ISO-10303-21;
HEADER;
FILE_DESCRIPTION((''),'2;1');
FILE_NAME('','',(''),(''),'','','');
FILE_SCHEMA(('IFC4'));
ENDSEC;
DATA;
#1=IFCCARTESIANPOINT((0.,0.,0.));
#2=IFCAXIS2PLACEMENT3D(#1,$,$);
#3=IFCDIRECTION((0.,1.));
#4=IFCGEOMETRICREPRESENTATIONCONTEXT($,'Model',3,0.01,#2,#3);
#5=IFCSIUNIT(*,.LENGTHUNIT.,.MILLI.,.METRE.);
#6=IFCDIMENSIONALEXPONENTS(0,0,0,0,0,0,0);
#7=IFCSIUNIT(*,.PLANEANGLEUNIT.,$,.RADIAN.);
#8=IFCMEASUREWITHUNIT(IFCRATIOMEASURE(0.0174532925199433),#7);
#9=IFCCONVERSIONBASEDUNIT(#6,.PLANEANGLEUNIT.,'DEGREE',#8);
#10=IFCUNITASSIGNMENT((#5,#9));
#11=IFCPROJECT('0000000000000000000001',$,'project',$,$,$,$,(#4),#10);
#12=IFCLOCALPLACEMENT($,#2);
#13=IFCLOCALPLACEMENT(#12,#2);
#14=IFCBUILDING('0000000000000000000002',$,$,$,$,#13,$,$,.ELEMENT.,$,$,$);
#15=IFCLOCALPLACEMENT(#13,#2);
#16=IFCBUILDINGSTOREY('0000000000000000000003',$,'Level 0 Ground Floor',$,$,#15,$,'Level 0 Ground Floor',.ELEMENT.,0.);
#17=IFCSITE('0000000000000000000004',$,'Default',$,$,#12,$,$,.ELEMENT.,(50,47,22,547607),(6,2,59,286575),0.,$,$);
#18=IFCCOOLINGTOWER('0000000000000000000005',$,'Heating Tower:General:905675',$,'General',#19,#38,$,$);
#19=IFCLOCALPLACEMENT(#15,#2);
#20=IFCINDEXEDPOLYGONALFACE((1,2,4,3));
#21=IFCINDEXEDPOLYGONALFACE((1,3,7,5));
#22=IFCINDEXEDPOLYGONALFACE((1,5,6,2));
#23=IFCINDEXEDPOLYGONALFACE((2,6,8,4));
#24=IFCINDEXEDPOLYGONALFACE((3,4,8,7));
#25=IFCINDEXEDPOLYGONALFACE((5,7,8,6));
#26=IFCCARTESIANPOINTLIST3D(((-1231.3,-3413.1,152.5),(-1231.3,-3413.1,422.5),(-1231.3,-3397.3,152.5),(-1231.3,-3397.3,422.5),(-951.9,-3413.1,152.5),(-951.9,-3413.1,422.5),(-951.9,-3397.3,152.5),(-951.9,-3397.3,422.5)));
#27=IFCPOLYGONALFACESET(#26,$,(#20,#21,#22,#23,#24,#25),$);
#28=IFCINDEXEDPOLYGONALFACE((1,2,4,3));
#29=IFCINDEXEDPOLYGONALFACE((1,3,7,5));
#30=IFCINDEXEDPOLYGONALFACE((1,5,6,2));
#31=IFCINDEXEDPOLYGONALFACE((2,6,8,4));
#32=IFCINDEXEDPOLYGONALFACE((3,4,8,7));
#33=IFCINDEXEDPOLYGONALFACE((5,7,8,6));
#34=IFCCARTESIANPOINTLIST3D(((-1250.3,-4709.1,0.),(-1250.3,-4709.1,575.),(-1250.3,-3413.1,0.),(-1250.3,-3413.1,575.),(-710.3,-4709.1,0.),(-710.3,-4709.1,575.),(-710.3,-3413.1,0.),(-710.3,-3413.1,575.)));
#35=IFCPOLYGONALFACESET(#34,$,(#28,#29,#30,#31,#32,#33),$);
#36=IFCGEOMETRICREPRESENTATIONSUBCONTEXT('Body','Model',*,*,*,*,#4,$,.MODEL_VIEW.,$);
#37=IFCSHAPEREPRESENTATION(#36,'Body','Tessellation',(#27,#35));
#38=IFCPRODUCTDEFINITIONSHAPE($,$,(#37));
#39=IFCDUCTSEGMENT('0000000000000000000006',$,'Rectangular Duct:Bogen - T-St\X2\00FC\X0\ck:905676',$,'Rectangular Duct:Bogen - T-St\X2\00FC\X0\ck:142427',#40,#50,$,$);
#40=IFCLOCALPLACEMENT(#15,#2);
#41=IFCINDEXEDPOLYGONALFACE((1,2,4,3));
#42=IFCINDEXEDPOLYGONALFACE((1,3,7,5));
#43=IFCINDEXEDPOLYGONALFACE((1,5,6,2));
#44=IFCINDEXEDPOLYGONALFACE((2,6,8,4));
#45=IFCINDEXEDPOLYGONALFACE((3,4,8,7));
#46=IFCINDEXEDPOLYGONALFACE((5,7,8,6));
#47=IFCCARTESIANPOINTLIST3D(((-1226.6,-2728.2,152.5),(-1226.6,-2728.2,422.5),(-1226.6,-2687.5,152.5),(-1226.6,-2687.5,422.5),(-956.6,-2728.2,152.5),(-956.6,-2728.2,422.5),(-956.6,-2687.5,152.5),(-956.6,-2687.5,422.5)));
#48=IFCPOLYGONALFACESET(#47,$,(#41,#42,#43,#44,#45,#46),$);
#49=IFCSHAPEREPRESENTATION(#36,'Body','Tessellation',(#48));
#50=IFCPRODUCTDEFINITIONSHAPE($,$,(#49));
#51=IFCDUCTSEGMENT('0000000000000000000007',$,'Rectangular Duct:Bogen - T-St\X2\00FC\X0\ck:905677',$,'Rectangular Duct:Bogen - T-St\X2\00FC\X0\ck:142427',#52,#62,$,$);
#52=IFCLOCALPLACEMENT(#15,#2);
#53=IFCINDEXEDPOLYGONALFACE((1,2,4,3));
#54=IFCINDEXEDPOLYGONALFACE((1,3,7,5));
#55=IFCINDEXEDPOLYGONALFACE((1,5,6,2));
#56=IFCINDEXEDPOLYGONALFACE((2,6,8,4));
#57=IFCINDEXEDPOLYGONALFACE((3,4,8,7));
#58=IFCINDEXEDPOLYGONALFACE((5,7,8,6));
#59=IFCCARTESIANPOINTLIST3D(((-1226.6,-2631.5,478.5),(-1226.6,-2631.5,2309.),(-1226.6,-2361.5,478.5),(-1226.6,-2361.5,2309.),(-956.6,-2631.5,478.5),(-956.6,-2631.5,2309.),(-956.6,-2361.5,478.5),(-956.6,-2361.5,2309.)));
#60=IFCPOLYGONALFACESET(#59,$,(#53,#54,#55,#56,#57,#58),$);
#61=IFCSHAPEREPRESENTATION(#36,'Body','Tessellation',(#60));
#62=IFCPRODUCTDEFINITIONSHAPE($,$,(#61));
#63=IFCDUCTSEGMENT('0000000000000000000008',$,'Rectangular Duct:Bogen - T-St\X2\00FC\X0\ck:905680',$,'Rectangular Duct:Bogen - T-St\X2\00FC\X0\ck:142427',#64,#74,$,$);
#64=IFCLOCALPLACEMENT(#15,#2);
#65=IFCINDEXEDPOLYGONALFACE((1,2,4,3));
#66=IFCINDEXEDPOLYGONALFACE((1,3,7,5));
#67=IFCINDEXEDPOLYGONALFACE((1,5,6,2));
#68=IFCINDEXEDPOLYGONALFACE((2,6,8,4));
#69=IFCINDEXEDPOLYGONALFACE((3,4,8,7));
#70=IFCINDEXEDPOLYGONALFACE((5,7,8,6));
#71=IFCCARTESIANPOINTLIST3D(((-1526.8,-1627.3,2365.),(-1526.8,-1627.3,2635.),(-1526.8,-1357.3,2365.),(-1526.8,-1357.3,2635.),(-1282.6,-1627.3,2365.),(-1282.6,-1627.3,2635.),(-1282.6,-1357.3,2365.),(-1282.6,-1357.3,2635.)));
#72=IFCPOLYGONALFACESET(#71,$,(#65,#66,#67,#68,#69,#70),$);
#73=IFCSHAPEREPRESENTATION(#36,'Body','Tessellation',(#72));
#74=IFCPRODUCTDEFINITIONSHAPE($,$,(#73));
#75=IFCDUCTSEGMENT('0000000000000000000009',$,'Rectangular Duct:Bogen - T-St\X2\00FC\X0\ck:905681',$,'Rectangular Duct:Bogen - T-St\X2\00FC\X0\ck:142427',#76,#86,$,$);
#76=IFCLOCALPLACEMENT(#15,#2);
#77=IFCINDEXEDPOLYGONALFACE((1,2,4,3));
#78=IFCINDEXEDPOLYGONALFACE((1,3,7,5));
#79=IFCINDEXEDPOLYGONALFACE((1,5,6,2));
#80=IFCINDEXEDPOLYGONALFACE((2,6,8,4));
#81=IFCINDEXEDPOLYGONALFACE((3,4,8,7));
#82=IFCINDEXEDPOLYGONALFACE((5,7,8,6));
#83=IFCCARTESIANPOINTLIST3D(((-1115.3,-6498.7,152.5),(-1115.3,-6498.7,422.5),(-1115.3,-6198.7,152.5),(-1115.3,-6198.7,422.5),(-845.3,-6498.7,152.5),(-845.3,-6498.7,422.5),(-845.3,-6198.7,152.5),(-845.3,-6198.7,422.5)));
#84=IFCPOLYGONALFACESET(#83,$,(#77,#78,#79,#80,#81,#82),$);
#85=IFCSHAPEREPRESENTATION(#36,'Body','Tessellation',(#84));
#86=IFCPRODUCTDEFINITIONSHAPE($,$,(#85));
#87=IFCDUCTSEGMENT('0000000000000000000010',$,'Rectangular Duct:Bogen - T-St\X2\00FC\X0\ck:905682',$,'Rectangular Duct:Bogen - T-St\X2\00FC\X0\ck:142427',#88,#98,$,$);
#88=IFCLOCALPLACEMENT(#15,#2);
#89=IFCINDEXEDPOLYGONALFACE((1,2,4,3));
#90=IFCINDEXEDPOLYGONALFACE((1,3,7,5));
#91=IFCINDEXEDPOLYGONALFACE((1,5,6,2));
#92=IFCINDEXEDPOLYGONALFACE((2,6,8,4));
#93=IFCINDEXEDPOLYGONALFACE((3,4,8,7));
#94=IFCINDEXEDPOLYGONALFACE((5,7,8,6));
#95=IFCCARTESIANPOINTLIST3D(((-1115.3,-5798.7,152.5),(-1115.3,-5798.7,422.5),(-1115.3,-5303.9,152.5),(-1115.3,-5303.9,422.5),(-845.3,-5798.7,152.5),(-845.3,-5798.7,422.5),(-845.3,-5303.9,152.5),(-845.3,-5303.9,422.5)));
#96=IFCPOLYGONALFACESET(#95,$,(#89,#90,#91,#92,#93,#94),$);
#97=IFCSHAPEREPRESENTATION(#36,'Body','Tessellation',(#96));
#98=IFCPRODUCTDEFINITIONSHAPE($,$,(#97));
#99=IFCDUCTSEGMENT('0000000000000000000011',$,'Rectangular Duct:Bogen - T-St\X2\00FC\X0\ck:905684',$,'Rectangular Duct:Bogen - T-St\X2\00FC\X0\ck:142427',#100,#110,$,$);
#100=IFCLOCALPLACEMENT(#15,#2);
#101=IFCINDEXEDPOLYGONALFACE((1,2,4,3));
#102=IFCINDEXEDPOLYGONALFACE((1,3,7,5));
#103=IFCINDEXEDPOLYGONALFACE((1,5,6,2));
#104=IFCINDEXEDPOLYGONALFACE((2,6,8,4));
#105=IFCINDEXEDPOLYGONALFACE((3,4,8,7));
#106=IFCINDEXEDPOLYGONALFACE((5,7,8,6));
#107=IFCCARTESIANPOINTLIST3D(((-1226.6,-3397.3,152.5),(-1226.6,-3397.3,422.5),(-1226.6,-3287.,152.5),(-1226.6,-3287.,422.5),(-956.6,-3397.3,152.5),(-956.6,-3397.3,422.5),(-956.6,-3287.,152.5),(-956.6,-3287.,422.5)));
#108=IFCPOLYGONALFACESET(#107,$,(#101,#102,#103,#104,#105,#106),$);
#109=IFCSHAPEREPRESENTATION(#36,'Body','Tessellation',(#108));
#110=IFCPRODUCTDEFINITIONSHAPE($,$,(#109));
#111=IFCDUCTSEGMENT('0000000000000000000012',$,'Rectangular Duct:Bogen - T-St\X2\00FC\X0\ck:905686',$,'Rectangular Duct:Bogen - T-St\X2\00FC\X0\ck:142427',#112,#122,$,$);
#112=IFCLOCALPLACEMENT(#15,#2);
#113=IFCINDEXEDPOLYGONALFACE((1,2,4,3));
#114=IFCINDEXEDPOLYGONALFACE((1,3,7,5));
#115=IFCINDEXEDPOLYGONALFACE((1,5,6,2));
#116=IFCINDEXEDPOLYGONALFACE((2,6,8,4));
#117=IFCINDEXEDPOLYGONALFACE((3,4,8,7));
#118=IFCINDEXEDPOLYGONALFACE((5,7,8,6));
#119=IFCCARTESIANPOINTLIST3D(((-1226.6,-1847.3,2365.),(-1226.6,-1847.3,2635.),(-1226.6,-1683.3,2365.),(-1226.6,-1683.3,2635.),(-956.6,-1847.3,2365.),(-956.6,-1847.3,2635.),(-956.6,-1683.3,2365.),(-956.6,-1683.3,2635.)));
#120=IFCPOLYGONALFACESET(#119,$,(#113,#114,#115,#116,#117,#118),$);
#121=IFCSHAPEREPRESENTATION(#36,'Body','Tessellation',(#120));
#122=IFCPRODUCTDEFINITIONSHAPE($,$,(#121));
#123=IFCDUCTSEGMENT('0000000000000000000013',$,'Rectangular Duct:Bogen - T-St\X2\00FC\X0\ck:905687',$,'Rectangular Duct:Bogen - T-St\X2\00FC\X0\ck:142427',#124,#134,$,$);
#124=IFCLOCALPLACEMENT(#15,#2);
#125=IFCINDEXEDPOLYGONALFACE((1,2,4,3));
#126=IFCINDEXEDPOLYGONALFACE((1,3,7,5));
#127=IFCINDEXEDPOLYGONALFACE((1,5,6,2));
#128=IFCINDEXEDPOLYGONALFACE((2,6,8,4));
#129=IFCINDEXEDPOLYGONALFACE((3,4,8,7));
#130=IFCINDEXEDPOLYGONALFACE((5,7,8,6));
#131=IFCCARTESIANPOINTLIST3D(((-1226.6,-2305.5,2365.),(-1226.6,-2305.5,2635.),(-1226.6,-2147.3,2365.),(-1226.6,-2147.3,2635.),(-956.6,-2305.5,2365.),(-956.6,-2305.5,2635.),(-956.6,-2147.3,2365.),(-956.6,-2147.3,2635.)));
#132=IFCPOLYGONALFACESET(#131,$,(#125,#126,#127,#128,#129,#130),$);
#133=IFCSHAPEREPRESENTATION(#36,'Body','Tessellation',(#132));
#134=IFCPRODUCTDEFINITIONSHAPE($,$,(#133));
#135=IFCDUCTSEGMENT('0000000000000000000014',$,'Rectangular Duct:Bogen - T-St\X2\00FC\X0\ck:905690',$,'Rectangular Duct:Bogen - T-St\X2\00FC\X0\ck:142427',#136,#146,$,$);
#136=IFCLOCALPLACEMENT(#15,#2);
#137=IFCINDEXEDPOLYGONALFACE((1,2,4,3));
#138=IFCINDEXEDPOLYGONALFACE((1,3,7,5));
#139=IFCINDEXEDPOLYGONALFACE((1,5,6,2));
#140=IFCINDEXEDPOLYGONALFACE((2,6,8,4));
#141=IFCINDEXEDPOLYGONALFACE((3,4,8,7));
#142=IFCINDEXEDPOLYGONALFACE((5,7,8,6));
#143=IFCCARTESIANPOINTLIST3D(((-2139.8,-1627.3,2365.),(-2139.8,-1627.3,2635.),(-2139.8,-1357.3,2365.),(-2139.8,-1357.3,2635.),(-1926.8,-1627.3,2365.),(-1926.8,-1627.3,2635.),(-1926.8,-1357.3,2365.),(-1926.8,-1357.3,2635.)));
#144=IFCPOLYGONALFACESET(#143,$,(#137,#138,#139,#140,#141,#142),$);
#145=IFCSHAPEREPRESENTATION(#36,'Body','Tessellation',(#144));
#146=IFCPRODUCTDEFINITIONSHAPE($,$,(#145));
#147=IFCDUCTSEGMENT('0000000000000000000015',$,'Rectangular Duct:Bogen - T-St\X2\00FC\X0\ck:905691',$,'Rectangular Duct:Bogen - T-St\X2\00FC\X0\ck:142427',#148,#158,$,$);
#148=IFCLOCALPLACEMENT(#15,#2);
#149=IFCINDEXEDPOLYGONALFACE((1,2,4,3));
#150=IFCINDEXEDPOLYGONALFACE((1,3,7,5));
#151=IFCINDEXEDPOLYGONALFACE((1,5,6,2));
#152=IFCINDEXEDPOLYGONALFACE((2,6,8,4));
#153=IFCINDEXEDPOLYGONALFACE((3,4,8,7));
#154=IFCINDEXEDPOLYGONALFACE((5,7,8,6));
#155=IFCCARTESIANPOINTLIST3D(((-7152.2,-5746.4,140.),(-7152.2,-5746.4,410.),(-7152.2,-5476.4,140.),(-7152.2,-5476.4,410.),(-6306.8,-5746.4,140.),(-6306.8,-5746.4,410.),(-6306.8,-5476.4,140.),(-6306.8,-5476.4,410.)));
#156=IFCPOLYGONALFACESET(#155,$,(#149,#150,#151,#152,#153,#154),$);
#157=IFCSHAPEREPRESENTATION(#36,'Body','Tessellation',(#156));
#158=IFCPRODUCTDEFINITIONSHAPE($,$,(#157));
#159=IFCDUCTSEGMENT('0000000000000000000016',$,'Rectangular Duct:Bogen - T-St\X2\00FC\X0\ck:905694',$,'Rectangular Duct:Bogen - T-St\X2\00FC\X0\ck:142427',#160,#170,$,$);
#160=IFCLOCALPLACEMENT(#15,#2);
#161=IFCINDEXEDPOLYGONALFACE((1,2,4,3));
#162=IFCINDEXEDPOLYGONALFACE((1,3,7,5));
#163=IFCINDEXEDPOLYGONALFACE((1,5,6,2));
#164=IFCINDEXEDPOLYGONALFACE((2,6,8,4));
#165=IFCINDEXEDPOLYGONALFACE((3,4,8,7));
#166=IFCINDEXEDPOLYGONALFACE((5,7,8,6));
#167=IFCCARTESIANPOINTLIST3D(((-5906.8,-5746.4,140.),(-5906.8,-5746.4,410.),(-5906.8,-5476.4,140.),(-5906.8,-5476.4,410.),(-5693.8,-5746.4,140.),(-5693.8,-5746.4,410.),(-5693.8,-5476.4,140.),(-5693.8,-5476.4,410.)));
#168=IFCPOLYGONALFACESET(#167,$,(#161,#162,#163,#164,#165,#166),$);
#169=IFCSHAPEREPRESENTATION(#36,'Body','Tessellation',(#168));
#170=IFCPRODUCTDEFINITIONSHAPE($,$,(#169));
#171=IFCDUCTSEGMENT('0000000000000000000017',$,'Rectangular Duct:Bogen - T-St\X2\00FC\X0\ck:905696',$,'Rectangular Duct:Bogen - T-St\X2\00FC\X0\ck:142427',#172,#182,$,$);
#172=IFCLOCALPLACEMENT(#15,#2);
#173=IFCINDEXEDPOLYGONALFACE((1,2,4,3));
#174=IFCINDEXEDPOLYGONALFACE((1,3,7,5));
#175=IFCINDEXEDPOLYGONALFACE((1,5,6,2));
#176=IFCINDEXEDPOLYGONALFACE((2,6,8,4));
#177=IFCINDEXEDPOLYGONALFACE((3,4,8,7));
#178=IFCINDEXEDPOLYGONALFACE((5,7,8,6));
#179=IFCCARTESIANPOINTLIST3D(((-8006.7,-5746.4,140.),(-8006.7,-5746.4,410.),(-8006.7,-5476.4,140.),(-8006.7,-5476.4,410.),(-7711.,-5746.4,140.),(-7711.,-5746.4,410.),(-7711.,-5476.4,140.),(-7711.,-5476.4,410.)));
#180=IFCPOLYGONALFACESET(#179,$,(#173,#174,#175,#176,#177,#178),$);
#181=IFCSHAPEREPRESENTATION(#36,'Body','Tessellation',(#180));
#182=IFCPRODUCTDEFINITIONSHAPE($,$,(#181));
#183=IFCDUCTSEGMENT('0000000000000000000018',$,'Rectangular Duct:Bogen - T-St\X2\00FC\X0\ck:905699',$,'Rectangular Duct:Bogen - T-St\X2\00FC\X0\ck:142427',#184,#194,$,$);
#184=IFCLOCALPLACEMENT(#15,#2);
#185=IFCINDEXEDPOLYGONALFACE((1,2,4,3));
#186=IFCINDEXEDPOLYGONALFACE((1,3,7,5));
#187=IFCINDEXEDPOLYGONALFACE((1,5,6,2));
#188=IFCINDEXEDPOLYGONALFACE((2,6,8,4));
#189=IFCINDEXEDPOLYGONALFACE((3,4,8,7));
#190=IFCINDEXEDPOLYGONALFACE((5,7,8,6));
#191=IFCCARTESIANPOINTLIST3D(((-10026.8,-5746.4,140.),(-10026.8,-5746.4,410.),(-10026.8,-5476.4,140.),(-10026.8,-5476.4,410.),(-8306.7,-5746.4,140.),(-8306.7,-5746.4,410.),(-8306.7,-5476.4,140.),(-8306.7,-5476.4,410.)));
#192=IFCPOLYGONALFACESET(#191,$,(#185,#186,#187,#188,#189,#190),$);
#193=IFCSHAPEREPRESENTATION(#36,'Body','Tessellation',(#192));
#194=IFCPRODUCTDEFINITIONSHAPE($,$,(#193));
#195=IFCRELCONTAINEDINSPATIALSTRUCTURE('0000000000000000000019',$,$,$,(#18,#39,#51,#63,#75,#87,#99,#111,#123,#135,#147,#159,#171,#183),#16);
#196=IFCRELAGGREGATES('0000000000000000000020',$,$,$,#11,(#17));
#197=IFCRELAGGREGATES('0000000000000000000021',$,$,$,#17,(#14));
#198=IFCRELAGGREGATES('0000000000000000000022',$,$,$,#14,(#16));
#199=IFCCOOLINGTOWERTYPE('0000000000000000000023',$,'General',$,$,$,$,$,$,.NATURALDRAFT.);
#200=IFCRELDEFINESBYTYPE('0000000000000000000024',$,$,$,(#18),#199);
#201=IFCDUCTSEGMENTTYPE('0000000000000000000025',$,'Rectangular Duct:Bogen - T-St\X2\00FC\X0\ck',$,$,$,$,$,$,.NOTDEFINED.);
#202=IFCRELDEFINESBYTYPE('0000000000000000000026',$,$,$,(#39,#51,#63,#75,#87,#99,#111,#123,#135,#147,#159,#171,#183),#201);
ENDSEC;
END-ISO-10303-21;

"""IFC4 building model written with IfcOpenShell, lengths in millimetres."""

from ifc_helpers import new_model, entity, si_unit, converted_unit, direction, frame, frame_2d, origin, origin_2d_with_axis, place, context, subcontext, project, spatial, rectangle, extrude, source, transform, mapped, type_object, type_shapes, element, save


model = new_model("IFC4")

# Units and contexts
model_context = context("Model", 3, precision=0.01, world=origin(), true_north=direction((0.0, 1.0)))
body_context = subcontext(model_context, "Body", "Model", "MODEL_VIEW")
ifc_project = project(units=[si_unit("LENGTHUNIT", "METRE", prefix="MILLI"), converted_unit("PLANEANGLEUNIT", "DEGREE", entity("IfcRatioMeasure", 0.0174532925199433), si_unit("PLANEANGLEUNIT", "RADIAN"), dimensions=[0, 0, 0, 0, 0, 0, 0])], contexts=[model_context])

# Site, building, storey
site_placement = place(None, origin())
site = spatial("IfcSite", under=ifc_project, at=site_placement, Name="Default", CompositionType="ELEMENT", RefLatitude=(50, 47, 22, 547607), RefLongitude=(6, 2, 59, 286575), RefElevation=0.0)
building_placement = place(site_placement, origin())
building = spatial("IfcBuilding", under=site, at=building_placement, CompositionType="ELEMENT")
storey_placement = place(building_placement, origin())
storey = spatial("IfcBuildingStorey", under=building, at=storey_placement, Name="Level 0 Ground Floor", LongName="Level 0 Ground Floor", CompositionType="ELEMENT", Elevation=0.0)

# Cooling tower
cooling_tower_type = type_object("IfcCoolingTowerType", Name="General", PredefinedType="NATURALDRAFT")
shared_shape_1 = source(origin(), body_context, "Body", "SweptSolid", [
    extrude(rectangle(XDim=15.9, YDim=279.4, at=frame_2d((0.0, 0.0), x_axis=(1.0, 0.0))), frame((1303.9, 381.3, 152.5)), (0.0, 0.0, 1.0), 270.0),
    extrude(rectangle(XDim=1296.0, YDim=540.0, at=origin_2d_with_axis()), frame((648.0, 270.0, 0.0), z_axis=(0.0, 0.0, 1.0), x_axis=(-1.0, 0.0, 0.0)), (0.0, 0.0, 1.0), 575.0),
])
type_shapes(cooling_tower_type, [shared_shape_1])
cooling_tower_placement = place(storey_placement, frame((-710.3, -4709.1, 0.0), z_axis=(0.0, 0.0, 1.0), x_axis=(0.0, 1.0, 0.0)))
element("IfcCoolingTower", 1, at=cooling_tower_placement, inside=storey, type_object=cooling_tower_type, Name="Heating Tower:General:905675", ObjectType="General", context=body_context, shape_type="MappedRepresentation", body=[
    mapped(shared_shape_1, transform((0.0, 0.0, 0.0), scale=1.0)),
])

# Duct segments
duct_segment_type = type_object("IfcDuctSegmentType", Name="Rectangular Duct:Bogen - T-Stück", PredefinedType="NOTDEFINED")
duct_segment_1_placement = place(storey_placement, frame((-1226.6, -2728.2, 152.5)))
element("IfcDuctSegment", 2, at=duct_segment_1_placement, inside=storey, type_object=duct_segment_type, Name="Rectangular Duct:Bogen - T-Stück:905676", ObjectType="Rectangular Duct:Bogen - T-Stück:142427", context=body_context, shape_type="SweptSolid", body=[
    extrude(rectangle(XDim=40.7, YDim=270.0, at=frame_2d((0.0, 0.0), x_axis=(1.0, 0.0))), frame((135.0, 20.4, 0.0), z_axis=(0.0, 0.0, 1.0), x_axis=(0.0, -1.0, 0.0)), (0.0, 0.0, 1.0), 270.0),
])
duct_segment_2_placement = place(storey_placement, frame((-1226.6, -2631.5, 478.5)))
element("IfcDuctSegment", 3, at=duct_segment_2_placement, inside=storey, type_object=duct_segment_type, Name="Rectangular Duct:Bogen - T-Stück:905677", ObjectType="Rectangular Duct:Bogen - T-Stück:142427", context=body_context, shape_type="SweptSolid", body=[
    extrude(rectangle(XDim=270.0, YDim=270.0, at=frame_2d((0.0, 0.0), x_axis=(1.0, 0.0))), frame((135.0, 135.0, 0.0), z_axis=(0.0, 0.0, 1.0), x_axis=(0.0, -1.0, 0.0)), (0.0, 0.0, 1.0), 1830.5),
])
duct_segment_3_placement = place(storey_placement, frame((-1526.8, -1627.3, 2365.0)))
element("IfcDuctSegment", 4, at=duct_segment_3_placement, inside=storey, type_object=duct_segment_type, Name="Rectangular Duct:Bogen - T-Stück:905680", ObjectType="Rectangular Duct:Bogen - T-Stück:142427", context=body_context, shape_type="SweptSolid", body=[
    extrude(rectangle(XDim=244.2, YDim=270.0, at=frame_2d((0.0, 0.0), x_axis=(1.0, 0.0))), frame((122.1, 135.0, 0.0), z_axis=(0.0, 0.0, 1.0), x_axis=(-1.0, 0.0, 0.0)), (0.0, 0.0, 1.0), 270.0),
])
duct_segment_4_placement = place(storey_placement, frame((-1115.3, -6498.7, 152.5)))
element("IfcDuctSegment", 5, at=duct_segment_4_placement, inside=storey, type_object=duct_segment_type, Name="Rectangular Duct:Bogen - T-Stück:905681", ObjectType="Rectangular Duct:Bogen - T-Stück:142427", context=body_context, shape_type="SweptSolid", body=[
    extrude(rectangle(XDim=300.0, YDim=270.0, at=frame_2d((0.0, 0.0), x_axis=(1.0, 0.0))), frame((135.0, 150.0, 0.0), z_axis=(0.0, 0.0, 1.0), x_axis=(0.0, -1.0, 0.0)), (0.0, 0.0, 1.0), 270.0),
])
duct_segment_5_placement = place(storey_placement, frame((-1115.3, -5798.7, 152.5)))
element("IfcDuctSegment", 6, at=duct_segment_5_placement, inside=storey, type_object=duct_segment_type, Name="Rectangular Duct:Bogen - T-Stück:905682", ObjectType="Rectangular Duct:Bogen - T-Stück:142427", context=body_context, shape_type="SweptSolid", body=[
    extrude(rectangle(XDim=494.8, YDim=270.0, at=frame_2d((0.0, 0.0), x_axis=(1.0, 0.0))), frame((135.0, 247.4, 0.0), z_axis=(0.0, 0.0, 1.0), x_axis=(0.0, -1.0, 0.0)), (0.0, 0.0, 1.0), 270.0),
])
duct_segment_6_placement = place(storey_placement, frame((-1226.6, -3397.3, 152.5)))
element("IfcDuctSegment", 7, at=duct_segment_6_placement, inside=storey, type_object=duct_segment_type, Name="Rectangular Duct:Bogen - T-Stück:905684", ObjectType="Rectangular Duct:Bogen - T-Stück:142427", context=body_context, shape_type="SweptSolid", body=[
    extrude(rectangle(XDim=110.2, YDim=270.0, at=origin_2d_with_axis()), frame((135.0, 55.1, 0.0), z_axis=(0.0, 0.0, 1.0), x_axis=(0.0, 1.0, 0.0)), (0.0, 0.0, 1.0), 270.0),
])
duct_segment_7_placement = place(storey_placement, frame((-1226.6, -1847.3, 2365.0)))
element("IfcDuctSegment", 8, at=duct_segment_7_placement, inside=storey, type_object=duct_segment_type, Name="Rectangular Duct:Bogen - T-Stück:905686", ObjectType="Rectangular Duct:Bogen - T-Stück:142427", context=body_context, shape_type="SweptSolid", body=[
    extrude(rectangle(XDim=164.0, YDim=270.0, at=frame_2d((0.0, 0.0), x_axis=(1.0, 0.0))), frame((135.0, 82.0, 0.0), z_axis=(0.0, 0.0, 1.0), x_axis=(0.0, -1.0, 0.0)), (0.0, 0.0, 1.0), 270.0),
])
duct_segment_8_placement = place(storey_placement, frame((-1226.6, -2305.5, 2365.0)))
element("IfcDuctSegment", 9, at=duct_segment_8_placement, inside=storey, type_object=duct_segment_type, Name="Rectangular Duct:Bogen - T-Stück:905687", ObjectType="Rectangular Duct:Bogen - T-Stück:142427", context=body_context, shape_type="SweptSolid", body=[
    extrude(rectangle(XDim=158.2, YDim=270.0, at=frame_2d((0.0, 0.0), x_axis=(1.0, 0.0))), frame((135.0, 79.1, 0.0), z_axis=(0.0, 0.0, 1.0), x_axis=(0.0, 1.0, 0.0)), (0.0, 0.0, 1.0), 270.0),
])
duct_segment_9_placement = place(storey_placement, frame((-2139.8, -1627.3, 2365.0)))
element("IfcDuctSegment", 10, at=duct_segment_9_placement, inside=storey, type_object=duct_segment_type, Name="Rectangular Duct:Bogen - T-Stück:905690", ObjectType="Rectangular Duct:Bogen - T-Stück:142427", context=body_context, shape_type="SweptSolid", body=[
    extrude(rectangle(XDim=213.0, YDim=270.0, at=origin_2d_with_axis()), frame((106.5, 135.0, 0.0)), (0.0, 0.0, 1.0), 270.0),
])
duct_segment_10_placement = place(storey_placement, frame((-7152.2, -5746.4, 140.0)))
element("IfcDuctSegment", 11, at=duct_segment_10_placement, inside=storey, type_object=duct_segment_type, Name="Rectangular Duct:Bogen - T-Stück:905691", ObjectType="Rectangular Duct:Bogen - T-Stück:142427", context=body_context, shape_type="SweptSolid", body=[
    extrude(rectangle(XDim=845.4, YDim=270.0, at=frame_2d((0.0, 0.0), x_axis=(1.0, 0.0))), frame((422.7, 135.0, 0.0), z_axis=(0.0, 0.0, 1.0), x_axis=(-1.0, 0.0, 0.0)), (0.0, 0.0, 1.0), 270.0),
])
duct_segment_11_placement = place(storey_placement, frame((-5906.8, -5746.4, 140.0)))
element("IfcDuctSegment", 12, at=duct_segment_11_placement, inside=storey, type_object=duct_segment_type, Name="Rectangular Duct:Bogen - T-Stück:905694", ObjectType="Rectangular Duct:Bogen - T-Stück:142427", context=body_context, shape_type="SweptSolid", body=[
    extrude(rectangle(XDim=213.0, YDim=270.0, at=frame_2d((0.0, 0.0), x_axis=(1.0, 0.0))), frame((106.5, 135.0, 0.0), z_axis=(0.0, 0.0, 1.0), x_axis=(-1.0, 0.0, 0.0)), (0.0, 0.0, 1.0), 270.0),
])
duct_segment_12_placement = place(storey_placement, frame((-8006.7, -5746.4, 140.0)))
element("IfcDuctSegment", 13, at=duct_segment_12_placement, inside=storey, type_object=duct_segment_type, Name="Rectangular Duct:Bogen - T-Stück:905696", ObjectType="Rectangular Duct:Bogen - T-Stück:142427", context=body_context, shape_type="SweptSolid", body=[
    extrude(rectangle(XDim=295.7, YDim=270.0, at=frame_2d((0.0, 0.0), x_axis=(1.0, 0.0))), frame((147.8, 135.0, 0.0)), (0.0, 0.0, 1.0), 270.0),
])
duct_segment_13_placement = place(storey_placement, frame((-10026.8, -5746.4, 140.0)))
element("IfcDuctSegment", 14, at=duct_segment_13_placement, inside=storey, type_object=duct_segment_type, Name="Rectangular Duct:Bogen - T-Stück:905699", ObjectType="Rectangular Duct:Bogen - T-Stück:142427", context=body_context, shape_type="SweptSolid", body=[
    extrude(rectangle(XDim=1720.1, YDim=270.0, at=frame_2d((0.0, 0.0), x_axis=(1.0, 0.0))), frame((860.0, 135.0, 0.0)), (0.0, 0.0, 1.0), 270.0),
])

save(model, "model.ifc")
